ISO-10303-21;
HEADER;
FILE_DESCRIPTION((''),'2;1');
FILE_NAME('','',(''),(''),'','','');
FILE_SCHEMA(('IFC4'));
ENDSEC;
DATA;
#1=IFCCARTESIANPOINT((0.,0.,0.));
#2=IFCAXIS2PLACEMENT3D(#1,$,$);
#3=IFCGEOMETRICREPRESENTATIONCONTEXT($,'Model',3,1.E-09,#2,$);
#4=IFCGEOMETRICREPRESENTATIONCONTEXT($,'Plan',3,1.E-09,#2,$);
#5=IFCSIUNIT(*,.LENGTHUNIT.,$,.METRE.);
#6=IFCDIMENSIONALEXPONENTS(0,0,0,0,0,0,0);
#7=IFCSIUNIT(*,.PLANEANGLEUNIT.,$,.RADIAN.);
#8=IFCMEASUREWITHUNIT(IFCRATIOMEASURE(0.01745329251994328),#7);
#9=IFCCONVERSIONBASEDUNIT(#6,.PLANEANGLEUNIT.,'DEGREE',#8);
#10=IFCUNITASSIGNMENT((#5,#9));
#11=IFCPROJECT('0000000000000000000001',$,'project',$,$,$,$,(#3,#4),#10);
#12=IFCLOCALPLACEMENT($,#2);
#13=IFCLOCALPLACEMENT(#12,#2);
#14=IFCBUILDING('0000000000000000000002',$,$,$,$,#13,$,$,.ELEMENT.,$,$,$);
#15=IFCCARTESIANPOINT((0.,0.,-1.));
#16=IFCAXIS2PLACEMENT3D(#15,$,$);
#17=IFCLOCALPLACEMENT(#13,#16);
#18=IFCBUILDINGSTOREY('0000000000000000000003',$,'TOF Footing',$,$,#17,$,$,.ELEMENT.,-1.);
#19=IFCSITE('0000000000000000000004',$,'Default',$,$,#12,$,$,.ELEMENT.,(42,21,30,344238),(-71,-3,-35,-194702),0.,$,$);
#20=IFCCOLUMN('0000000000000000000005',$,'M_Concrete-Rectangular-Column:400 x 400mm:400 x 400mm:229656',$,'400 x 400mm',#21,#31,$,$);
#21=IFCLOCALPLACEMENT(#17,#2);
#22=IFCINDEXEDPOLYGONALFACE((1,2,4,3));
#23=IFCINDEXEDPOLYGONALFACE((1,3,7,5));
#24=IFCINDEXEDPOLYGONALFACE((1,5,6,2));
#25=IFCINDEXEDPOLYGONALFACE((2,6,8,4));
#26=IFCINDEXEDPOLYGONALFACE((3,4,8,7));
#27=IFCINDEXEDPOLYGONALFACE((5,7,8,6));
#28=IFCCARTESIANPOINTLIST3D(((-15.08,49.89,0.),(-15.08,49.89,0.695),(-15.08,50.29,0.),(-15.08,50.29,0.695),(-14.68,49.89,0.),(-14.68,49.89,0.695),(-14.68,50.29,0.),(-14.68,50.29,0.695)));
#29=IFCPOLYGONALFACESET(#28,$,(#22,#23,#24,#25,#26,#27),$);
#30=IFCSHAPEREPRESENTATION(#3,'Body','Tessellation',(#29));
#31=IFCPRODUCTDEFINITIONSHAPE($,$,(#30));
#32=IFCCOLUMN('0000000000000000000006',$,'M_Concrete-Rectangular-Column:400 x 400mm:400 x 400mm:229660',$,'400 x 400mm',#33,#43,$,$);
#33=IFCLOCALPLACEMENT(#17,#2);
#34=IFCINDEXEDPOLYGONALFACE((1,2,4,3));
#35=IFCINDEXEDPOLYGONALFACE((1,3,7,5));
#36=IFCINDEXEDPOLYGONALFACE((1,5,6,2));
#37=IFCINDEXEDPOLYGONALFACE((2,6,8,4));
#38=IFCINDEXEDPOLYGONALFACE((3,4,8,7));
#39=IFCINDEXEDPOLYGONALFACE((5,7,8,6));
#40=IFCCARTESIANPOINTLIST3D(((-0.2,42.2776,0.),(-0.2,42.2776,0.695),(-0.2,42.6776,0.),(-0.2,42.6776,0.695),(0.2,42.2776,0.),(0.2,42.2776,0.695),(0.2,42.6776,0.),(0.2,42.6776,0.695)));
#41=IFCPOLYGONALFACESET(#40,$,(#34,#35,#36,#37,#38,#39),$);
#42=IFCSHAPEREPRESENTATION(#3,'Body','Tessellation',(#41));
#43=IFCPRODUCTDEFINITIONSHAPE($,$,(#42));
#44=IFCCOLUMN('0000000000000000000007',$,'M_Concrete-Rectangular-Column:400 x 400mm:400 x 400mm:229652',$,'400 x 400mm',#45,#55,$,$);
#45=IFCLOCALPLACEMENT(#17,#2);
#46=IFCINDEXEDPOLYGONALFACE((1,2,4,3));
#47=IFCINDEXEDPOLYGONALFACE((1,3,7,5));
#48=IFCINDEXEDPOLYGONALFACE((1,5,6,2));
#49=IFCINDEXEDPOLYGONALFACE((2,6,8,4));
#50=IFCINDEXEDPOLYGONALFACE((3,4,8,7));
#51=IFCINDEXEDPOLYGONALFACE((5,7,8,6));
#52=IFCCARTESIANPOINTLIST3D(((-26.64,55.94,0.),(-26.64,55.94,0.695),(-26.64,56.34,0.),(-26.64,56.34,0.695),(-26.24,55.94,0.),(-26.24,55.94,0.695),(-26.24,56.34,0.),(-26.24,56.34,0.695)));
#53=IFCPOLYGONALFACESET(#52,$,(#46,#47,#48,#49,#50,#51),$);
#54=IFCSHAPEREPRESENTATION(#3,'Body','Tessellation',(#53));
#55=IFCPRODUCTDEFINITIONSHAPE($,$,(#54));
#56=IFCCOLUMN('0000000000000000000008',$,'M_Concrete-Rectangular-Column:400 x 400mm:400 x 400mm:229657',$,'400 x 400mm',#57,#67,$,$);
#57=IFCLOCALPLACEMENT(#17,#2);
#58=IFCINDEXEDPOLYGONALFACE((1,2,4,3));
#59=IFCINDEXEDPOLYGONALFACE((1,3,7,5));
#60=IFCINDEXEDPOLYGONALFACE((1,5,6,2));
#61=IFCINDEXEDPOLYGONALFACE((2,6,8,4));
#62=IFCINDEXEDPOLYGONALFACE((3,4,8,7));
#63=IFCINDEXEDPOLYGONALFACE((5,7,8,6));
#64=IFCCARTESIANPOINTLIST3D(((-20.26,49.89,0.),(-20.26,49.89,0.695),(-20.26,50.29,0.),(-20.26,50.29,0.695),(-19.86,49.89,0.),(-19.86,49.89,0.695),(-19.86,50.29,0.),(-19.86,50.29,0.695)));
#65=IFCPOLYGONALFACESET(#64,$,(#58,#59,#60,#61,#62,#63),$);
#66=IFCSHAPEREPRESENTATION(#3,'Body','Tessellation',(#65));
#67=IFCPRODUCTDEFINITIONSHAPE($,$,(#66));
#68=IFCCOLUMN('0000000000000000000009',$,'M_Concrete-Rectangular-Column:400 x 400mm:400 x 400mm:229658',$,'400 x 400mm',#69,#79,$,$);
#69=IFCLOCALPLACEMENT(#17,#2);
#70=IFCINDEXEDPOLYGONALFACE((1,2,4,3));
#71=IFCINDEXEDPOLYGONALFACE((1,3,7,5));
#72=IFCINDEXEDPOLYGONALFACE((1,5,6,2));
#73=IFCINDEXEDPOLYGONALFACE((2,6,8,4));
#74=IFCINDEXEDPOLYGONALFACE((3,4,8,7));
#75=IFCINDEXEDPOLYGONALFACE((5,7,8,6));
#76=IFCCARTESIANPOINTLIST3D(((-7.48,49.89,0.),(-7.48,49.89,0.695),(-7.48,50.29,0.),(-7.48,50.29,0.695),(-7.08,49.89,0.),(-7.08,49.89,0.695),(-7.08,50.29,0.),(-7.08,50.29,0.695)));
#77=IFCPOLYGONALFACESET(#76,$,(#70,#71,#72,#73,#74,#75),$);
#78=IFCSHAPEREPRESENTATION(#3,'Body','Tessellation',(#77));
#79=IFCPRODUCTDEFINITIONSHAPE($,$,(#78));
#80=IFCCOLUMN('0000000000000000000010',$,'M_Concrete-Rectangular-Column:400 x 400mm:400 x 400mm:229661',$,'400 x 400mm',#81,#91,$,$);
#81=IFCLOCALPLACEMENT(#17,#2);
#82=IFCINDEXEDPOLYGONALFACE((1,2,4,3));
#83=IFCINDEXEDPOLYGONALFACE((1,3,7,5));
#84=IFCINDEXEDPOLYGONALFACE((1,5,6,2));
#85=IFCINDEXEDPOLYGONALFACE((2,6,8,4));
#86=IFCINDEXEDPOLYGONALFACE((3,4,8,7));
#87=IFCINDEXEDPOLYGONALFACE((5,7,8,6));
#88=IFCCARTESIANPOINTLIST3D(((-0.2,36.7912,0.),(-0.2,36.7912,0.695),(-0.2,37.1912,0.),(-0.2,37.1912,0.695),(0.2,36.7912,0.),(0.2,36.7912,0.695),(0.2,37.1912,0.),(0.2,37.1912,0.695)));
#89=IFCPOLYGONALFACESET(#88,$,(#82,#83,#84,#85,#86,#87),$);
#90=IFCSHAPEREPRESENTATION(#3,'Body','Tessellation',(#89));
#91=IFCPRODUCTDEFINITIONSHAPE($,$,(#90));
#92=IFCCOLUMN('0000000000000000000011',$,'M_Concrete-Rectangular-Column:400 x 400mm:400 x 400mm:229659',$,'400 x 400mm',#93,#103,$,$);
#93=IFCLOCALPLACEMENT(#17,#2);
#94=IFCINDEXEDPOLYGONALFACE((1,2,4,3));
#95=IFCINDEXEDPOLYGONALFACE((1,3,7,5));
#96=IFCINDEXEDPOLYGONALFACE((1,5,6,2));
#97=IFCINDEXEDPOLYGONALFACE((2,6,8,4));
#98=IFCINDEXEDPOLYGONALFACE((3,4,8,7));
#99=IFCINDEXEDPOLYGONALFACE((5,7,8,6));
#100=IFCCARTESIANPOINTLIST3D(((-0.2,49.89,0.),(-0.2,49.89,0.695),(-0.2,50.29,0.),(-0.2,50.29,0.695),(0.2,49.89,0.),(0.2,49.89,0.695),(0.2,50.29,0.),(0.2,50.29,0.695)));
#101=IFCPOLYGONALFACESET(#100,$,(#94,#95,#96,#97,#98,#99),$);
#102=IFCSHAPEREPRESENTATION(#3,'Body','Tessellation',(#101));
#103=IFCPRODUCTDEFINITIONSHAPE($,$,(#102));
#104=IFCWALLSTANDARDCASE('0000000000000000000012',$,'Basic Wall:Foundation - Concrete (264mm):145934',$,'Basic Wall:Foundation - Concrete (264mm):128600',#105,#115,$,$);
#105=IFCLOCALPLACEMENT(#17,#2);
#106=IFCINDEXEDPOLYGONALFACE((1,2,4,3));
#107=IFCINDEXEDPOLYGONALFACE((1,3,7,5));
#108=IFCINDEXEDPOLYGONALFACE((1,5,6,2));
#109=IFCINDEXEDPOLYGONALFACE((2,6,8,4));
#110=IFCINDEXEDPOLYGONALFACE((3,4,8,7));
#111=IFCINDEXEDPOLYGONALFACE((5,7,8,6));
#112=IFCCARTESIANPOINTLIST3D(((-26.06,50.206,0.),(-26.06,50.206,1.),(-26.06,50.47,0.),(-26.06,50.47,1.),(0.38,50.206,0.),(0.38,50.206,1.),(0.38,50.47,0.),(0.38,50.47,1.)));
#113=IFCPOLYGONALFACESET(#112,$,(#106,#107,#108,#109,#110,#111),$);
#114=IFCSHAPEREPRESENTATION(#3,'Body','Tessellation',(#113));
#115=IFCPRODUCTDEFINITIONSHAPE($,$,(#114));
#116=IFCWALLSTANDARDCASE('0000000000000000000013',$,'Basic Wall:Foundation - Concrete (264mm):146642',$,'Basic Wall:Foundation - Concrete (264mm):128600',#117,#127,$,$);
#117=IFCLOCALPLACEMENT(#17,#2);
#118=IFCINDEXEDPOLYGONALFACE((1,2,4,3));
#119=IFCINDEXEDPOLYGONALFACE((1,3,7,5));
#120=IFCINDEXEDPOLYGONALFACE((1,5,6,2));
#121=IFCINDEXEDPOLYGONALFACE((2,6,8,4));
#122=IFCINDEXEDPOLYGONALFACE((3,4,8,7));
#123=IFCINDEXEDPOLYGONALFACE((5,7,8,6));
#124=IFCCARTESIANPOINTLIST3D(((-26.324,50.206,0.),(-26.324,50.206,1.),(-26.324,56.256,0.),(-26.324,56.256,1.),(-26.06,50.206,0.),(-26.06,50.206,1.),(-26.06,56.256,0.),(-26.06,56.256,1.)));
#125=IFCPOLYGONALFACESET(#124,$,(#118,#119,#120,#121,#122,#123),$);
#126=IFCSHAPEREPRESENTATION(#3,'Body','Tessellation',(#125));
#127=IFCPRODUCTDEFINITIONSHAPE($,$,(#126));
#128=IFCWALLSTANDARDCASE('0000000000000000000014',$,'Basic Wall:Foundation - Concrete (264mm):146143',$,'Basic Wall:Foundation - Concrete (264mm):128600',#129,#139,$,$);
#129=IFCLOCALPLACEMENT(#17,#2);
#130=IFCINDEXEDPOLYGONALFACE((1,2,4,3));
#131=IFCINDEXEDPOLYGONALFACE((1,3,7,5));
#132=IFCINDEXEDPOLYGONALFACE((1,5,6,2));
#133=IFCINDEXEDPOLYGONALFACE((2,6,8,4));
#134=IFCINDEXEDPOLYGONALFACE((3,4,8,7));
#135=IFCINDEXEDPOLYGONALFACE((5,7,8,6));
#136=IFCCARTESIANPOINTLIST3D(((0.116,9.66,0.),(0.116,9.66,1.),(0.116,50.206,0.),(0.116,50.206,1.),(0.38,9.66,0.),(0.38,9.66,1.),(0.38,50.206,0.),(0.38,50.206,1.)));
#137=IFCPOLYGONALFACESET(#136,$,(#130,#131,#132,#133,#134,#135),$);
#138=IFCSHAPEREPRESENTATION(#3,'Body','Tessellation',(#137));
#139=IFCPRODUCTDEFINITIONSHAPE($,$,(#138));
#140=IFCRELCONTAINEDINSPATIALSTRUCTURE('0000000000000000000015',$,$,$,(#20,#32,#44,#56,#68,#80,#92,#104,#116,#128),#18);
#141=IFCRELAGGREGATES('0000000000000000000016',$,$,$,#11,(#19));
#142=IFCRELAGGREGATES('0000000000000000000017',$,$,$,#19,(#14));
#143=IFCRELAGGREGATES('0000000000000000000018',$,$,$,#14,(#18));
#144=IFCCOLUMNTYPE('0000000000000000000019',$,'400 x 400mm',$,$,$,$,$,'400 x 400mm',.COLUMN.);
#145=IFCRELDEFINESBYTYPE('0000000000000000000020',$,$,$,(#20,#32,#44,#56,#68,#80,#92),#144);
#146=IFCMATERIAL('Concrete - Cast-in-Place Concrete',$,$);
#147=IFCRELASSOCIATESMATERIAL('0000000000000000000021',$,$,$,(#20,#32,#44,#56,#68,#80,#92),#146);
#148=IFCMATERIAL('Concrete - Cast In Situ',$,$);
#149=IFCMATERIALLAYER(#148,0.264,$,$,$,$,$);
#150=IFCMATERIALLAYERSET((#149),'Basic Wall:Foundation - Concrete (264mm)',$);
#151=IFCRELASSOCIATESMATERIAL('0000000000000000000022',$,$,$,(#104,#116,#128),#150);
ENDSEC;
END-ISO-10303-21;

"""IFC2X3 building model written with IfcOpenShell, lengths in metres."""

from ifc_helpers import new_model, entity, si_unit, converted_unit, frame, frame_2d, origin, place, context, project, spatial, rectangle, extrude, source, transform, mapped, material, layer, layer_set, layer_usage, type_object, type_shapes, element, save


model = new_model("IFC2X3")

# Units and contexts
model_context = context("Model", 3, precision=1e-09, world=origin())
plan_context = context("Plan", 3, precision=1e-09, world=origin())
ifc_project = project(units=[si_unit("LENGTHUNIT", "METRE"), converted_unit("PLANEANGLEUNIT", "DEGREE", entity("IfcRatioMeasure", 0.01745329251994328), si_unit("PLANEANGLEUNIT", "RADIAN"), dimensions=[0, 0, 0, 0, 0, 0, 0])], contexts=[model_context, plan_context])

# Site, building, storey
site_placement = place(None, origin())
site = spatial("IfcSite", under=ifc_project, at=site_placement, Name="Default", CompositionType="ELEMENT", RefLatitude=(42, 21, 30, 344238), RefLongitude=(-71, -3, -35, -194702), RefElevation=0.0)
building_placement = place(site_placement, origin())
building = spatial("IfcBuilding", under=site, at=building_placement, CompositionType="ELEMENT")
storey_placement = place(building_placement, frame((0.0, 0.0, -1.0)))
storey = spatial("IfcBuildingStorey", under=building, at=storey_placement, Name="TOF Footing", CompositionType="ELEMENT", Elevation=-1.0)

# Columns
ifc_material_1 = material(Name="Concrete - Cast-in-Place Concrete")
column_type_1 = type_object("IfcColumnType", Name="400 x 400mm", ElementType="400 x 400mm", PredefinedType="COLUMN")
shared_shape_1 = source(origin(), model_context, "Body", "SweptSolid", [
    extrude(rectangle(XDim=0.4, YDim=0.4, at=frame_2d((0.0, 0.0), x_axis=(0.0, -1.0))), origin(), (0.0, 0.0, 1.0), 0.695),
])
type_shapes(column_type_1, [shared_shape_1])
for number, where, z_axis, x_axis, name in (
    (1, (-14.88, 50.09, 0.0), (0.0, 0.0, 1.0), (0.0, 1.0, 0.0), "M_Concrete-Rectangular-Column:400 x 400mm:400 x 400mm:229656"),
    (2, (0.0, 42.4776, 0.0), (0.0, 0.0, 1.0), (-1.0, 0.0, 0.0), "M_Concrete-Rectangular-Column:400 x 400mm:400 x 400mm:229660"),
    (3, (-26.44, 56.14, 0.0), (0.0, 0.0, 1.0), (0.0, 1.0, 0.0), "M_Concrete-Rectangular-Column:400 x 400mm:400 x 400mm:229652"),
    (4, (-20.06, 50.09, 0.0), (0.0, 0.0, 1.0), (0.0, 1.0, 0.0), "M_Concrete-Rectangular-Column:400 x 400mm:400 x 400mm:229657"),
    (5, (-7.28, 50.09, 0.0), (0.0, 0.0, 1.0), (0.0, 1.0, 0.0), "M_Concrete-Rectangular-Column:400 x 400mm:400 x 400mm:229658"),
    (6, (0.0, 36.9912, 0.0), (0.0, 0.0, 1.0), (-1.0, 0.0, 0.0), "M_Concrete-Rectangular-Column:400 x 400mm:400 x 400mm:229661"),
    (7, (0.0, 50.09, 0.0), (0.0, 0.0, 1.0), (0.0, 1.0, 0.0), "M_Concrete-Rectangular-Column:400 x 400mm:400 x 400mm:229659"),
):
    element("IfcColumn", number, at=place(storey_placement, frame(where, z_axis=z_axis, x_axis=x_axis)), inside=storey, type_object=column_type_1, material=ifc_material_1, Name=name, ObjectType="400 x 400mm", context=model_context, shape_type="MappedRepresentation", body=[
        mapped(shared_shape_1, transform((0.0, 0.0, 0.0), scale=1.0)),
    ])

# Walls
ifc_material_2 = material(Name="Concrete - Cast In Situ")
ifc_layer = layer(ifc_material_2, 0.264)
ifc_layer_set = layer_set([ifc_layer], Name="Basic Wall:Foundation - Concrete (264mm)")
ifc_layer_usage = layer_usage(ifc_layer_set, "AXIS2", "NEGATIVE", 0.132)
wall_1_placement = place(storey_placement, frame((-26.06, 50.338, 0.0)))
element("IfcWallStandardCase", 8, at=wall_1_placement, inside=storey, material=ifc_layer_usage, Name="Basic Wall:Foundation - Concrete (264mm):145934", ObjectType="Basic Wall:Foundation - Concrete (264mm):128600", context=model_context, shape_type="SweptSolid", body=[
    extrude(rectangle(XDim=26.44, YDim=0.264, at=frame_2d((13.22, 0.0), x_axis=(-1.0, 0.0))), origin(), (0.0, 0.0, 1.0), 1.0),
])
wall_2_placement = place(storey_placement, frame((-26.192, 56.256, 0.0), z_axis=(0.0, 0.0, 1.0), x_axis=(0.0, -1.0, 0.0)))
element("IfcWallStandardCase", 9, at=wall_2_placement, inside=storey, material=ifc_layer_usage, Name="Basic Wall:Foundation - Concrete (264mm):146642", ObjectType="Basic Wall:Foundation - Concrete (264mm):128600", context=model_context, shape_type="SweptSolid", body=[
    extrude(rectangle(XDim=6.05, YDim=0.264, at=frame_2d((3.025, 0.0), x_axis=(-1.0, 0.0))), origin(), (0.0, 0.0, 1.0), 1.0),
])
wall_3_placement = place(storey_placement, frame((0.248, 50.206, 0.0), z_axis=(0.0, 0.0, 1.0), x_axis=(0.0, -1.0, 0.0)))
element("IfcWallStandardCase", 10, at=wall_3_placement, inside=storey, material=ifc_layer_usage, Name="Basic Wall:Foundation - Concrete (264mm):146143", ObjectType="Basic Wall:Foundation - Concrete (264mm):128600", context=model_context, shape_type="SweptSolid", body=[
    extrude(rectangle(XDim=40.546, YDim=0.264, at=frame_2d((20.273, 0.0), x_axis=(-1.0, 0.0))), origin(), (0.0, 0.0, 1.0), 1.0),
])

save(model, "model.ifc")
